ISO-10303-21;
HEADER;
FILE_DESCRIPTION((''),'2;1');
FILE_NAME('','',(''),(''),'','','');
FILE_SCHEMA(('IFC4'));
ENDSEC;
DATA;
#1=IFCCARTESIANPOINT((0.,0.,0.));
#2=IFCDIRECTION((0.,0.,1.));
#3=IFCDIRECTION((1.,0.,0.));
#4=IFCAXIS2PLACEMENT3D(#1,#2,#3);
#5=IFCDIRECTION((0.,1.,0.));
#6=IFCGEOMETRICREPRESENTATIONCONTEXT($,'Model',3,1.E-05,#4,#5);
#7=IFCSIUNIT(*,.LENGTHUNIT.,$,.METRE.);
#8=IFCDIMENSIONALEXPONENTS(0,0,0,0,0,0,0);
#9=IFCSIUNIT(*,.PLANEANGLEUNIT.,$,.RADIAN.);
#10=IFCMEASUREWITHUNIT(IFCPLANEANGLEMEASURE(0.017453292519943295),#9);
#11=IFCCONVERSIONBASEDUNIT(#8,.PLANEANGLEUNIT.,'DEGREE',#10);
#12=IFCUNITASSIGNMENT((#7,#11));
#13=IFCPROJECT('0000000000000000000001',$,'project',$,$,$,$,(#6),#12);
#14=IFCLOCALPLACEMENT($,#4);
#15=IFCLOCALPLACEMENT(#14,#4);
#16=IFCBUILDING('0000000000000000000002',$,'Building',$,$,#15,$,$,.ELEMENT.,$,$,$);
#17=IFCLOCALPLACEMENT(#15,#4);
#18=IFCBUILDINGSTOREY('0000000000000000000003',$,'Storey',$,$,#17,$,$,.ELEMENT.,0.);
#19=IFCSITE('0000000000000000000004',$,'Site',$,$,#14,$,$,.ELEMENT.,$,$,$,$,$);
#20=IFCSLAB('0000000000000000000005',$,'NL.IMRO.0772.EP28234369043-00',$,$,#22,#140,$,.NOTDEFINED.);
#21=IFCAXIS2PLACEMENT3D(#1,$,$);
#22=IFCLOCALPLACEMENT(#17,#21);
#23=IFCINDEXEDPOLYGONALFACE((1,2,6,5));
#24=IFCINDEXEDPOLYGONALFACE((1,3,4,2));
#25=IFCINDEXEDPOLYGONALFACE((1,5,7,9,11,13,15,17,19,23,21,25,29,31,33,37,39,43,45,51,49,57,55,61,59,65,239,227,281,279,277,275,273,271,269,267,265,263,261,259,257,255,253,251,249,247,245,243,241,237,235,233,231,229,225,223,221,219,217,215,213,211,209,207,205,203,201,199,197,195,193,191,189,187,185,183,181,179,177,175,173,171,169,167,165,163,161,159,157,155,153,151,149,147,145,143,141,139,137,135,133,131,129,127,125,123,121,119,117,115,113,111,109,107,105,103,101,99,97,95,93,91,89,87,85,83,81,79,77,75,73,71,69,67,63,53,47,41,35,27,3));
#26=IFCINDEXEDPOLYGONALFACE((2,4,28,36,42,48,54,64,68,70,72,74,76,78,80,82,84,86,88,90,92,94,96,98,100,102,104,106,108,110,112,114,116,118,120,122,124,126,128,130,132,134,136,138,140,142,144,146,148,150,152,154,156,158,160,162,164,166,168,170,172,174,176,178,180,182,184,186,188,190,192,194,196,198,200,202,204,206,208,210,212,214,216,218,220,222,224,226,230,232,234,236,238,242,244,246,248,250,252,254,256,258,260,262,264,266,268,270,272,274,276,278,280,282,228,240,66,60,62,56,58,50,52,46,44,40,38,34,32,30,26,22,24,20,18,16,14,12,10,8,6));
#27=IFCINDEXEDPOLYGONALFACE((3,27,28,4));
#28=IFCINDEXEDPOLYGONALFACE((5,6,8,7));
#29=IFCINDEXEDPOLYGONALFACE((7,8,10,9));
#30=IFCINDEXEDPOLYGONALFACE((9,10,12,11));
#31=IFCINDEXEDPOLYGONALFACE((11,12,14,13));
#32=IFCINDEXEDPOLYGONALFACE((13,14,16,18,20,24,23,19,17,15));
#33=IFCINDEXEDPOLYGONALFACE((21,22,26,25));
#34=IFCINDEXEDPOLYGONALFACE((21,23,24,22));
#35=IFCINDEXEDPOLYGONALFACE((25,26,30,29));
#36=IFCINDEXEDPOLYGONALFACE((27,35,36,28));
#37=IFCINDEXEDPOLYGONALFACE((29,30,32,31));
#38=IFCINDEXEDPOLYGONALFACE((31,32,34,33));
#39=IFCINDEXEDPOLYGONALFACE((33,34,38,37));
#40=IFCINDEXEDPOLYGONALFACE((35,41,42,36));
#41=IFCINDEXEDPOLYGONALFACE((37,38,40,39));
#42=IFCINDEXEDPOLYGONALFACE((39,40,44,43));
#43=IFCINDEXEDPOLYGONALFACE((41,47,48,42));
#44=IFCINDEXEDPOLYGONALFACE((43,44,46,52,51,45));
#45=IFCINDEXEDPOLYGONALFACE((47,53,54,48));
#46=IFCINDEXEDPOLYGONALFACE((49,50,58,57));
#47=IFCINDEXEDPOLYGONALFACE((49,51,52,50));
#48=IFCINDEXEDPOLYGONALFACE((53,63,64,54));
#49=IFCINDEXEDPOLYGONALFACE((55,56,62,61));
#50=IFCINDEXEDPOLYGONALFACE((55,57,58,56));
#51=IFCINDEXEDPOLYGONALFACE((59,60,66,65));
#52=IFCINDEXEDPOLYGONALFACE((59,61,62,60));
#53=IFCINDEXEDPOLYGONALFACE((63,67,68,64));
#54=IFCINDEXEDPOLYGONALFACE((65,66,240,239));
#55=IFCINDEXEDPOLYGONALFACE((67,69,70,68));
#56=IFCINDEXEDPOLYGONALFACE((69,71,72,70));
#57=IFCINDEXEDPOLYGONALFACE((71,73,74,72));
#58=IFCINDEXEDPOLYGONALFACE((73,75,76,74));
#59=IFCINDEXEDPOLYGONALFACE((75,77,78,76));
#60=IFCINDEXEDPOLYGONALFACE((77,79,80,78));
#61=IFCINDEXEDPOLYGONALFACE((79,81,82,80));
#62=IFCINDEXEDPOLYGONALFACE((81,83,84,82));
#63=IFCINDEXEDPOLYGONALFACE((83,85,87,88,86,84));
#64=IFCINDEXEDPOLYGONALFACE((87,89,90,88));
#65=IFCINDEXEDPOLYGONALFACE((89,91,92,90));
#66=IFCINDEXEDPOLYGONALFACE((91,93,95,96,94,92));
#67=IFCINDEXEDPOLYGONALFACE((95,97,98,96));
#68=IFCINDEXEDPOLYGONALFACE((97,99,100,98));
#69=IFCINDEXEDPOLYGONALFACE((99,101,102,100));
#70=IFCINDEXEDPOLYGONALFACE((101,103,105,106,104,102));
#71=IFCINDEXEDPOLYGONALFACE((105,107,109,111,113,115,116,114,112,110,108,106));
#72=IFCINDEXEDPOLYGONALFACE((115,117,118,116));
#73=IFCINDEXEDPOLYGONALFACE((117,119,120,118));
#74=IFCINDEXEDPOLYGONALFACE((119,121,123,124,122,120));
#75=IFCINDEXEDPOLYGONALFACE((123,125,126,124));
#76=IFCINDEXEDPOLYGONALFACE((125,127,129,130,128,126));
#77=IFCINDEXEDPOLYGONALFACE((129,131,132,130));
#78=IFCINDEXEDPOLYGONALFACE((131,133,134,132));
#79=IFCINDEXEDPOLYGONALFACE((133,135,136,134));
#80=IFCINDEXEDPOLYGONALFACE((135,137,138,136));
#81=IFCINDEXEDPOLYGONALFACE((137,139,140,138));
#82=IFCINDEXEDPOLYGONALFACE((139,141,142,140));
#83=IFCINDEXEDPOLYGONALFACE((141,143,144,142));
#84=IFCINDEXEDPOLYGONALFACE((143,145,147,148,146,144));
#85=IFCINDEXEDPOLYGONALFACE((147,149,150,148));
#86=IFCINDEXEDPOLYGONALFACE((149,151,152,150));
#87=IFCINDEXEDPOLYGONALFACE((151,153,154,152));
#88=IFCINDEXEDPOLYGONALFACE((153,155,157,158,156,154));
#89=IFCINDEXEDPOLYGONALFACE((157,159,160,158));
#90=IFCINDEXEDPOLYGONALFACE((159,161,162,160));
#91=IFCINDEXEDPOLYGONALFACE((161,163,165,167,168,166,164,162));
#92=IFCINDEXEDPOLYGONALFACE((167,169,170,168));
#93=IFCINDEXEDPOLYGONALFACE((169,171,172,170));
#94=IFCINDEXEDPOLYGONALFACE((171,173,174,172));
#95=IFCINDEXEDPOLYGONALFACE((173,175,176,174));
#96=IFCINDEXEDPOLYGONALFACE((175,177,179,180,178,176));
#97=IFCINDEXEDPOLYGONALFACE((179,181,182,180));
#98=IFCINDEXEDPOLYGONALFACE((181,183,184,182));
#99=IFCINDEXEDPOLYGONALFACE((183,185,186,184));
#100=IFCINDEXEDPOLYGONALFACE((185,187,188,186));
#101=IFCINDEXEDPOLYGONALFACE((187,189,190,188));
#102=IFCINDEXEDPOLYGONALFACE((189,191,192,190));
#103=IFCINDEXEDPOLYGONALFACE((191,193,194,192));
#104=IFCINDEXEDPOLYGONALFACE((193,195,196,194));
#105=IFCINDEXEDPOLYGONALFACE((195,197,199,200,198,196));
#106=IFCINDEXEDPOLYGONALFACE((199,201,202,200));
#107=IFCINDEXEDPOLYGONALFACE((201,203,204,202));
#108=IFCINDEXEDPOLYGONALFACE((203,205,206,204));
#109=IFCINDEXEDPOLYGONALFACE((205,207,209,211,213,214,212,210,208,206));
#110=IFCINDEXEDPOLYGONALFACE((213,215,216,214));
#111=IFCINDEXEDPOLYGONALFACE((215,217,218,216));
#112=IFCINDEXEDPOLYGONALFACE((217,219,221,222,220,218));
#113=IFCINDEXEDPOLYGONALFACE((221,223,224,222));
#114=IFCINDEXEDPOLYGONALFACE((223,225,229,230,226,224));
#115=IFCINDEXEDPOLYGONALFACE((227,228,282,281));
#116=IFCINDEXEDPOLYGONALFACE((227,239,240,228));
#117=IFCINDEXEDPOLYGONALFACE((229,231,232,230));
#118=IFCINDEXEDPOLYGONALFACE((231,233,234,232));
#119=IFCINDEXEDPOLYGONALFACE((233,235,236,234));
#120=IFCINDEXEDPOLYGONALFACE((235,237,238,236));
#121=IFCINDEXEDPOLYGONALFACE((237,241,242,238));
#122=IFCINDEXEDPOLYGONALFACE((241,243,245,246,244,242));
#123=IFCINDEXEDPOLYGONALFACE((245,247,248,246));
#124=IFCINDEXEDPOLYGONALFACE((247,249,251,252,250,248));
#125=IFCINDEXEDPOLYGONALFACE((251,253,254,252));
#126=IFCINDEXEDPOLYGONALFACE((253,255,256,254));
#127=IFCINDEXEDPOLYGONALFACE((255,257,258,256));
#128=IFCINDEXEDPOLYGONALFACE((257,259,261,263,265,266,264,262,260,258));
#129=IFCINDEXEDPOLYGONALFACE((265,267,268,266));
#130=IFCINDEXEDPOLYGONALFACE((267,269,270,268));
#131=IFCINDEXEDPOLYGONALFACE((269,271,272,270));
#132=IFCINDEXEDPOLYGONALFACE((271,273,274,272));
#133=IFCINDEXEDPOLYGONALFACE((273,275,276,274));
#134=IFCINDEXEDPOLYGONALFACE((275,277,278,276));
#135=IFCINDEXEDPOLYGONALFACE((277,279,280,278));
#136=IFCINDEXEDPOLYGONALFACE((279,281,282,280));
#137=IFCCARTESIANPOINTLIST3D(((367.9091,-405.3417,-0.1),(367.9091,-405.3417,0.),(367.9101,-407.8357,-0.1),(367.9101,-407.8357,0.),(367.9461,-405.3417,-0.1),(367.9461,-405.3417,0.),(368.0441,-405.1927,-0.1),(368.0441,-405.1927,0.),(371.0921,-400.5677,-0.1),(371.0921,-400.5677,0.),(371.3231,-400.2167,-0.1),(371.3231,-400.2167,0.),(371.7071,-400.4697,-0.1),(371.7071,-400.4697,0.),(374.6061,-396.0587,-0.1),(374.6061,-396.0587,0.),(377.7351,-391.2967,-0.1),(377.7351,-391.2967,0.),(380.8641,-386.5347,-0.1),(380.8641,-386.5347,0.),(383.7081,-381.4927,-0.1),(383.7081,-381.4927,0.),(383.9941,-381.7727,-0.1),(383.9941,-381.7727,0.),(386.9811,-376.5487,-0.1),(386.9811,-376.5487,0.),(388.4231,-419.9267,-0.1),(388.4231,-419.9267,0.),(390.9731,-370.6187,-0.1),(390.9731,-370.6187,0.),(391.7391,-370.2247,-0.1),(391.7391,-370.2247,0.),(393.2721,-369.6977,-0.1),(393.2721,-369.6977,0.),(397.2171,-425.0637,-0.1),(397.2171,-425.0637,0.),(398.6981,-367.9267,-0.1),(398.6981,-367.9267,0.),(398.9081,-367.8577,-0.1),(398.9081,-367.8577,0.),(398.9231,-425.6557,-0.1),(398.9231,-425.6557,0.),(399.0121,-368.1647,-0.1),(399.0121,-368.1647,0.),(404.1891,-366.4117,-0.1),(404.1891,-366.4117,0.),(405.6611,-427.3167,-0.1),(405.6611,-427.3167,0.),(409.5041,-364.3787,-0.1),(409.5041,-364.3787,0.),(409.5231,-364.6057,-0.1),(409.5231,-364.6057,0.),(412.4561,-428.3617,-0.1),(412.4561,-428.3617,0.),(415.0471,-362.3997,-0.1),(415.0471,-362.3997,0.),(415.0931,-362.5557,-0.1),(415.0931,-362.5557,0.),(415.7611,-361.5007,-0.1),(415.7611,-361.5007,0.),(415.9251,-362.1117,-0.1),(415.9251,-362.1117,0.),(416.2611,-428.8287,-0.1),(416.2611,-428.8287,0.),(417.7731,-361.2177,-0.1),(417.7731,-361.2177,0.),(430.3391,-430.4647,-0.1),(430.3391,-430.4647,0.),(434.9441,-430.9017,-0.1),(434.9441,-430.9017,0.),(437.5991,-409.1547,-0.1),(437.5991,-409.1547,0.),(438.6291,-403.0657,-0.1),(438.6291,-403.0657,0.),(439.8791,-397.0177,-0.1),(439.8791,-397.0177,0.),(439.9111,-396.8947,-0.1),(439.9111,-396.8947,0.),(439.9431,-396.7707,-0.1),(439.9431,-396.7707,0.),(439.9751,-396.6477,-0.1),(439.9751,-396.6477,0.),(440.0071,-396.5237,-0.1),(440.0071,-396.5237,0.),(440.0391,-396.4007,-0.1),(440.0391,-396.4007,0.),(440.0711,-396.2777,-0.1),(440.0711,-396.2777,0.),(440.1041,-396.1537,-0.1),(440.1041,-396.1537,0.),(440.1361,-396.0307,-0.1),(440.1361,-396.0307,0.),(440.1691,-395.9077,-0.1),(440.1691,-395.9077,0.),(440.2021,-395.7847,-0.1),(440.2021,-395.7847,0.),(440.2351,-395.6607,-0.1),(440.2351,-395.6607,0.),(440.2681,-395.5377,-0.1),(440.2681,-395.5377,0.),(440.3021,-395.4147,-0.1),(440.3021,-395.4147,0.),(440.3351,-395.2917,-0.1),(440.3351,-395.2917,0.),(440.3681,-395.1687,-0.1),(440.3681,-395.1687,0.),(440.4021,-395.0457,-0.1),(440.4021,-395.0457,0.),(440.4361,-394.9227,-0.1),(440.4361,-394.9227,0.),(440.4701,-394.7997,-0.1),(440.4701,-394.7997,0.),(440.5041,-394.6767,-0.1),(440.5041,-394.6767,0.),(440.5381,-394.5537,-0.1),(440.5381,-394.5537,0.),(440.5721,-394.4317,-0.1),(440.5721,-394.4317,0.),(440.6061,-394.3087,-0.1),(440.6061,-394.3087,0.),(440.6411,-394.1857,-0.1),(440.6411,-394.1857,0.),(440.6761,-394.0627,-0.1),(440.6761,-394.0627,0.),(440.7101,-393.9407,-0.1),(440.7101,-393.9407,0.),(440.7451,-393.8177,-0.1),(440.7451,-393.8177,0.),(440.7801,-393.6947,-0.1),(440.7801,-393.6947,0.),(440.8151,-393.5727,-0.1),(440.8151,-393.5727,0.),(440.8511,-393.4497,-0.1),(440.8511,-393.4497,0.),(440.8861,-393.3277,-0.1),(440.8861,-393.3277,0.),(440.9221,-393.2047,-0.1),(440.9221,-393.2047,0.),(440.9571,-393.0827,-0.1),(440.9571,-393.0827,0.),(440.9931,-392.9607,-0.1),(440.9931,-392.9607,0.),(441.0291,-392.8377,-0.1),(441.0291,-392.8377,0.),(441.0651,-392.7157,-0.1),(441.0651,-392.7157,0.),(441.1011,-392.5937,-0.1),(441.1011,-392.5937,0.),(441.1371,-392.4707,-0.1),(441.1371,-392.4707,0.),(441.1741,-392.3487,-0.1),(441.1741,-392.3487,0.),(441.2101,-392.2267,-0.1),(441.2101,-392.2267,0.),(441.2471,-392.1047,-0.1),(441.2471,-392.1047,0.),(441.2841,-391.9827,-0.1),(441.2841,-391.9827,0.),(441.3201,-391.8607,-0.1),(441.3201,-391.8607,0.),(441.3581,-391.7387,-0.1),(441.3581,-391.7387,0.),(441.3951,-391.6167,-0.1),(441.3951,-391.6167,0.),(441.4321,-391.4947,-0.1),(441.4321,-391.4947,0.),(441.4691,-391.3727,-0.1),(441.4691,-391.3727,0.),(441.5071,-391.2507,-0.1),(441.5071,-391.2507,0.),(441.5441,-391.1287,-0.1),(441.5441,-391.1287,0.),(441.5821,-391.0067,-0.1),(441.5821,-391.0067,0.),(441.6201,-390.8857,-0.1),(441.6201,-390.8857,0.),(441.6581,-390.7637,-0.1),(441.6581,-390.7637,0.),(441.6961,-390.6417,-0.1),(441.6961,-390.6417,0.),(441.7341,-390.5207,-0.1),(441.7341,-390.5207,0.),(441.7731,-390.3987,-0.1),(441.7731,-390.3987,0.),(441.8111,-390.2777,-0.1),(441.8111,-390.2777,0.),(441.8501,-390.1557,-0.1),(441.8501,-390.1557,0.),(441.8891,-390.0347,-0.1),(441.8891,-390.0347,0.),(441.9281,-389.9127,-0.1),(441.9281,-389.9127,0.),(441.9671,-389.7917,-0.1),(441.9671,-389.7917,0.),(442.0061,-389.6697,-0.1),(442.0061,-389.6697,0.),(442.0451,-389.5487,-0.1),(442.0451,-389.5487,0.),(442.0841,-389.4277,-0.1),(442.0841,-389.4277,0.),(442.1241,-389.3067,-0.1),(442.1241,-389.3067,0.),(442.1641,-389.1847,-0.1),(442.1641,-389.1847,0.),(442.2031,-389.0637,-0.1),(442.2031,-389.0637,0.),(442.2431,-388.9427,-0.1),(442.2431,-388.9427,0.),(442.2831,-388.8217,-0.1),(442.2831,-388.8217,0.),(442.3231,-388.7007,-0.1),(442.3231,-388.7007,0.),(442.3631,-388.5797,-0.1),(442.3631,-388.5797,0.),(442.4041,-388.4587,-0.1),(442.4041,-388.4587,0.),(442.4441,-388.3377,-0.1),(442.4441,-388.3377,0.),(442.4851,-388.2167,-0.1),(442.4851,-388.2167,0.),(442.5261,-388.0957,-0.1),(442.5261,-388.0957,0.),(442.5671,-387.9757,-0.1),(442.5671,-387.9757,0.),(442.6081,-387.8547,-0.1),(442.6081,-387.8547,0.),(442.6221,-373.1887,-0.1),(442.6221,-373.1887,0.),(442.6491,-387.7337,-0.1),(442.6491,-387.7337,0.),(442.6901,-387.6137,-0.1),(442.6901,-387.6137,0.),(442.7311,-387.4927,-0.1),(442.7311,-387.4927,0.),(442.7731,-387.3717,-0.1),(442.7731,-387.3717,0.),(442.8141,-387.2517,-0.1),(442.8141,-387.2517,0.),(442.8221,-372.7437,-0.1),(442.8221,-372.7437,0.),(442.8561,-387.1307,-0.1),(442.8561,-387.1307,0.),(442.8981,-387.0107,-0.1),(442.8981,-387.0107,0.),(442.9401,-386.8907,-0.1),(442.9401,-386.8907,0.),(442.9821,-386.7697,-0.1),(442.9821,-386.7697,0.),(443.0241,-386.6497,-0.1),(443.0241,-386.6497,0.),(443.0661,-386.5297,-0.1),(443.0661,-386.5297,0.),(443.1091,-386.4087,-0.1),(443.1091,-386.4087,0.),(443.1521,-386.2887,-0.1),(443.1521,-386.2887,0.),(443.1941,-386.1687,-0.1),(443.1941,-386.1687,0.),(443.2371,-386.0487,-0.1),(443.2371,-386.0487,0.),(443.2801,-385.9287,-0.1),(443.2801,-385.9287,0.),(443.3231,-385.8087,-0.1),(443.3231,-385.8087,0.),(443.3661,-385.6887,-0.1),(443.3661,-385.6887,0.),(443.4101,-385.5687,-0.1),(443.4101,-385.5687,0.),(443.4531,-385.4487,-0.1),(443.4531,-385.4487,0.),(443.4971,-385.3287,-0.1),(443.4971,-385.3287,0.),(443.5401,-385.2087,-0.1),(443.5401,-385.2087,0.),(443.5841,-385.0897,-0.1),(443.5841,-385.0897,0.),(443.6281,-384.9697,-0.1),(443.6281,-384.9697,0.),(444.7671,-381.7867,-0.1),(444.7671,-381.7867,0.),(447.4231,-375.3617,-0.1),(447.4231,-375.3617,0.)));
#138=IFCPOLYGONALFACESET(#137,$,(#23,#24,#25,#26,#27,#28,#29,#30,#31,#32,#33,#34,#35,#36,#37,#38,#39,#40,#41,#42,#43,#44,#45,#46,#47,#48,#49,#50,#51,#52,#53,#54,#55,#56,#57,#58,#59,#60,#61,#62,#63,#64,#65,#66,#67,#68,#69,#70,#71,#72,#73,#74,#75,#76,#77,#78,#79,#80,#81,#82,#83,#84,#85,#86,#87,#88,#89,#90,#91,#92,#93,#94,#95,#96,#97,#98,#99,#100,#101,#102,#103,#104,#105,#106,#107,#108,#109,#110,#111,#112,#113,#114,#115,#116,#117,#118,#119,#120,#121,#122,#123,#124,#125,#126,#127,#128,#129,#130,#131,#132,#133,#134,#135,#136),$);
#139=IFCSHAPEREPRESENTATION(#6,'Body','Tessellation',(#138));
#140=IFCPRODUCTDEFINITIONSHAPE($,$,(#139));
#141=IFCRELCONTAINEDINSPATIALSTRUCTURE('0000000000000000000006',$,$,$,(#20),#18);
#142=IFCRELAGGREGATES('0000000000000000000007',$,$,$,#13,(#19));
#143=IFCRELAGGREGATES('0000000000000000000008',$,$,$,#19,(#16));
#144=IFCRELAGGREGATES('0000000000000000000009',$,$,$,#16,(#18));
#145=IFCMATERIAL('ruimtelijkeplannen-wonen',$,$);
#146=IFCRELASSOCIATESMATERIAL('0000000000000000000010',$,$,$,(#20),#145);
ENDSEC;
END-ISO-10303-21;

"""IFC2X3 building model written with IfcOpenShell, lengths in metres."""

from ifc_helpers import new_model, entity, si_unit, converted_unit, direction, frame, origin_with_axes, place, context, project, spatial, polyline, outline, extrude, material, element, save


model = new_model("IFC2X3")

# Units and contexts
model_context = context("Model", 3, precision=1e-05, world=origin_with_axes(), true_north=direction((0.0, 1.0, 0.0)))
ifc_project = project(units=[si_unit("LENGTHUNIT", "METRE"), converted_unit("PLANEANGLEUNIT", "DEGREE", entity("IfcPlaneAngleMeasure", 0.017453292519943295), si_unit("PLANEANGLEUNIT", "RADIAN"), dimensions=[0, 0, 0, 0, 0, 0, 0])], contexts=[model_context])

# Site, building, storey
site_placement = place(None, origin_with_axes())
site = spatial("IfcSite", under=ifc_project, at=site_placement, Name="Site", CompositionType="ELEMENT")
building_placement = place(site_placement, origin_with_axes())
building = spatial("IfcBuilding", under=site, at=building_placement, Name="Building", CompositionType="ELEMENT")
storey_placement = place(building_placement, origin_with_axes())
storey = spatial("IfcBuildingStorey", under=building, at=storey_placement, Name="Storey", CompositionType="ELEMENT", Elevation=0.0)

# Slab
ifc_material_1 = material(Name="ruimtelijkeplannen-wonen")
slab_1_placement = place(storey_placement, frame((0.0, 0.0, -0.1), z_axis=(0.0, 0.0, 1.0), x_axis=(1.0, 0.0, 0.0)))
element("IfcSlab", 1, at=slab_1_placement, inside=storey, material=ifc_material_1, Name="NL.IMRO.0772.EP28234369043-00", PredefinedType="NOTDEFINED", context=model_context, shape_type="SweptSolid", body=[
    extrude(outline(polyline([(443.5841, -385.0897), (443.5401, -385.2087), (443.4971, -385.3287), (443.4531, -385.4487), (443.4101, -385.5687), (443.3661, -385.6887), (443.3231, -385.8087), (443.2801, -385.9287), (443.2371, -386.0487), (443.1941, -386.1687), (443.1521, -386.2887), (443.1091, -386.4087), (443.0661, -386.5297), (443.0241, -386.6497), (442.9821, -386.7697), (442.9401, -386.8907), (442.8981, -387.0107), (442.8561, -387.1307), (442.8141, -387.2517), (442.7731, -387.3717), (442.7311, -387.4927), (442.6901, -387.6137), (442.6491, -387.7337), (442.6081, -387.8547), (442.5671, -387.9757), (442.5261, -388.0957), (442.4851, -388.2167), (442.4441, -388.3377), (442.4041, -388.4587), (442.3631, -388.5797), (442.3231, -388.7007), (442.2831, -388.8217), (442.2431, -388.9427), (442.2031, -389.0637), (442.1641, -389.1847), (442.1241, -389.3067), (442.0841, -389.4277), (442.0451, -389.5487), (442.0061, -389.6697), (441.9671, -389.7917), (441.9281, -389.9127), (441.8891, -390.0347), (441.8501, -390.1557), (441.8111, -390.2777), (441.7731, -390.3987), (441.7341, -390.5207), (441.6961, -390.6417), (441.6581, -390.7637), (441.6201, -390.8857), (441.5821, -391.0067), (441.5441, -391.1287), (441.5071, -391.2507), (441.4691, -391.3727), (441.4321, -391.4947), (441.3951, -391.6167), (441.3581, -391.7387), (441.3201, -391.8607), (441.2841, -391.9827), (441.2471, -392.1047), (441.2101, -392.2267), (441.1741, -392.3487), (441.1371, -392.4707), (441.1011, -392.5937), (441.0651, -392.7157), (441.0291, -392.8377), (440.9931, -392.9607), (440.9571, -393.0827), (440.9221, -393.2047), (440.8861, -393.3277), (440.8511, -393.4497), (440.8151, -393.5727), (440.7801, -393.6947), (440.7451, -393.8177), (440.7101, -393.9407), (440.6761, -394.0627), (440.6411, -394.1857), (440.6061, -394.3087), (440.5721, -394.4317), (440.5381, -394.5537), (440.5041, -394.6767), (440.4701, -394.7997), (440.4361, -394.9227), (440.4021, -395.0457), (440.3681, -395.1687), (440.3351, -395.2917), (440.3021, -395.4147), (440.2681, -395.5377), (440.2351, -395.6607), (440.2021, -395.7847), (440.1691, -395.9077), (440.1361, -396.0307), (440.1041, -396.1537), (440.0711, -396.2777), (440.0391, -396.4007), (440.0071, -396.5237), (439.9751, -396.6477), (439.9431, -396.7707), (439.9111, -396.8947), (439.8791, -397.0177), (438.6291, -403.0657), (437.5991, -409.1547), (434.9441, -430.9017), (430.3391, -430.4647), (416.2611, -428.8287), (412.4561, -428.3617), (405.6611, -427.3167), (398.9231, -425.6557), (397.2171, -425.0637), (388.4231, -419.9267), (367.9101, -407.8357), (367.9091, -405.3417), (367.9461, -405.3417), (368.0441, -405.1927), (371.0921, -400.5677), (371.3231, -400.2167), (371.7071, -400.4697), (374.6061, -396.0587), (377.7351, -391.2967), (380.8641, -386.5347), (383.9941, -381.7727), (383.7081, -381.4927), (386.9811, -376.5487), (390.9731, -370.6187), (391.7391, -370.2247), (393.2721, -369.6977), (398.6981, -367.9267), (398.9081, -367.8577), (399.0121, -368.1647), (404.1891, -366.4117), (409.5231, -364.6057), (409.5041, -364.3787), (415.0931, -362.5557), (415.0471, -362.3997), (415.9251, -362.1117), (415.7611, -361.5007), (417.7731, -361.2177), (442.8221, -372.7437), (442.6221, -373.1887), (447.4231, -375.3617), (444.7671, -381.7867), (443.6281, -384.9697), (443.5841, -385.0897)])), origin_with_axes(), (0.0, 0.0, 1.0), 0.1),
])

save(model, "model.ifc")
